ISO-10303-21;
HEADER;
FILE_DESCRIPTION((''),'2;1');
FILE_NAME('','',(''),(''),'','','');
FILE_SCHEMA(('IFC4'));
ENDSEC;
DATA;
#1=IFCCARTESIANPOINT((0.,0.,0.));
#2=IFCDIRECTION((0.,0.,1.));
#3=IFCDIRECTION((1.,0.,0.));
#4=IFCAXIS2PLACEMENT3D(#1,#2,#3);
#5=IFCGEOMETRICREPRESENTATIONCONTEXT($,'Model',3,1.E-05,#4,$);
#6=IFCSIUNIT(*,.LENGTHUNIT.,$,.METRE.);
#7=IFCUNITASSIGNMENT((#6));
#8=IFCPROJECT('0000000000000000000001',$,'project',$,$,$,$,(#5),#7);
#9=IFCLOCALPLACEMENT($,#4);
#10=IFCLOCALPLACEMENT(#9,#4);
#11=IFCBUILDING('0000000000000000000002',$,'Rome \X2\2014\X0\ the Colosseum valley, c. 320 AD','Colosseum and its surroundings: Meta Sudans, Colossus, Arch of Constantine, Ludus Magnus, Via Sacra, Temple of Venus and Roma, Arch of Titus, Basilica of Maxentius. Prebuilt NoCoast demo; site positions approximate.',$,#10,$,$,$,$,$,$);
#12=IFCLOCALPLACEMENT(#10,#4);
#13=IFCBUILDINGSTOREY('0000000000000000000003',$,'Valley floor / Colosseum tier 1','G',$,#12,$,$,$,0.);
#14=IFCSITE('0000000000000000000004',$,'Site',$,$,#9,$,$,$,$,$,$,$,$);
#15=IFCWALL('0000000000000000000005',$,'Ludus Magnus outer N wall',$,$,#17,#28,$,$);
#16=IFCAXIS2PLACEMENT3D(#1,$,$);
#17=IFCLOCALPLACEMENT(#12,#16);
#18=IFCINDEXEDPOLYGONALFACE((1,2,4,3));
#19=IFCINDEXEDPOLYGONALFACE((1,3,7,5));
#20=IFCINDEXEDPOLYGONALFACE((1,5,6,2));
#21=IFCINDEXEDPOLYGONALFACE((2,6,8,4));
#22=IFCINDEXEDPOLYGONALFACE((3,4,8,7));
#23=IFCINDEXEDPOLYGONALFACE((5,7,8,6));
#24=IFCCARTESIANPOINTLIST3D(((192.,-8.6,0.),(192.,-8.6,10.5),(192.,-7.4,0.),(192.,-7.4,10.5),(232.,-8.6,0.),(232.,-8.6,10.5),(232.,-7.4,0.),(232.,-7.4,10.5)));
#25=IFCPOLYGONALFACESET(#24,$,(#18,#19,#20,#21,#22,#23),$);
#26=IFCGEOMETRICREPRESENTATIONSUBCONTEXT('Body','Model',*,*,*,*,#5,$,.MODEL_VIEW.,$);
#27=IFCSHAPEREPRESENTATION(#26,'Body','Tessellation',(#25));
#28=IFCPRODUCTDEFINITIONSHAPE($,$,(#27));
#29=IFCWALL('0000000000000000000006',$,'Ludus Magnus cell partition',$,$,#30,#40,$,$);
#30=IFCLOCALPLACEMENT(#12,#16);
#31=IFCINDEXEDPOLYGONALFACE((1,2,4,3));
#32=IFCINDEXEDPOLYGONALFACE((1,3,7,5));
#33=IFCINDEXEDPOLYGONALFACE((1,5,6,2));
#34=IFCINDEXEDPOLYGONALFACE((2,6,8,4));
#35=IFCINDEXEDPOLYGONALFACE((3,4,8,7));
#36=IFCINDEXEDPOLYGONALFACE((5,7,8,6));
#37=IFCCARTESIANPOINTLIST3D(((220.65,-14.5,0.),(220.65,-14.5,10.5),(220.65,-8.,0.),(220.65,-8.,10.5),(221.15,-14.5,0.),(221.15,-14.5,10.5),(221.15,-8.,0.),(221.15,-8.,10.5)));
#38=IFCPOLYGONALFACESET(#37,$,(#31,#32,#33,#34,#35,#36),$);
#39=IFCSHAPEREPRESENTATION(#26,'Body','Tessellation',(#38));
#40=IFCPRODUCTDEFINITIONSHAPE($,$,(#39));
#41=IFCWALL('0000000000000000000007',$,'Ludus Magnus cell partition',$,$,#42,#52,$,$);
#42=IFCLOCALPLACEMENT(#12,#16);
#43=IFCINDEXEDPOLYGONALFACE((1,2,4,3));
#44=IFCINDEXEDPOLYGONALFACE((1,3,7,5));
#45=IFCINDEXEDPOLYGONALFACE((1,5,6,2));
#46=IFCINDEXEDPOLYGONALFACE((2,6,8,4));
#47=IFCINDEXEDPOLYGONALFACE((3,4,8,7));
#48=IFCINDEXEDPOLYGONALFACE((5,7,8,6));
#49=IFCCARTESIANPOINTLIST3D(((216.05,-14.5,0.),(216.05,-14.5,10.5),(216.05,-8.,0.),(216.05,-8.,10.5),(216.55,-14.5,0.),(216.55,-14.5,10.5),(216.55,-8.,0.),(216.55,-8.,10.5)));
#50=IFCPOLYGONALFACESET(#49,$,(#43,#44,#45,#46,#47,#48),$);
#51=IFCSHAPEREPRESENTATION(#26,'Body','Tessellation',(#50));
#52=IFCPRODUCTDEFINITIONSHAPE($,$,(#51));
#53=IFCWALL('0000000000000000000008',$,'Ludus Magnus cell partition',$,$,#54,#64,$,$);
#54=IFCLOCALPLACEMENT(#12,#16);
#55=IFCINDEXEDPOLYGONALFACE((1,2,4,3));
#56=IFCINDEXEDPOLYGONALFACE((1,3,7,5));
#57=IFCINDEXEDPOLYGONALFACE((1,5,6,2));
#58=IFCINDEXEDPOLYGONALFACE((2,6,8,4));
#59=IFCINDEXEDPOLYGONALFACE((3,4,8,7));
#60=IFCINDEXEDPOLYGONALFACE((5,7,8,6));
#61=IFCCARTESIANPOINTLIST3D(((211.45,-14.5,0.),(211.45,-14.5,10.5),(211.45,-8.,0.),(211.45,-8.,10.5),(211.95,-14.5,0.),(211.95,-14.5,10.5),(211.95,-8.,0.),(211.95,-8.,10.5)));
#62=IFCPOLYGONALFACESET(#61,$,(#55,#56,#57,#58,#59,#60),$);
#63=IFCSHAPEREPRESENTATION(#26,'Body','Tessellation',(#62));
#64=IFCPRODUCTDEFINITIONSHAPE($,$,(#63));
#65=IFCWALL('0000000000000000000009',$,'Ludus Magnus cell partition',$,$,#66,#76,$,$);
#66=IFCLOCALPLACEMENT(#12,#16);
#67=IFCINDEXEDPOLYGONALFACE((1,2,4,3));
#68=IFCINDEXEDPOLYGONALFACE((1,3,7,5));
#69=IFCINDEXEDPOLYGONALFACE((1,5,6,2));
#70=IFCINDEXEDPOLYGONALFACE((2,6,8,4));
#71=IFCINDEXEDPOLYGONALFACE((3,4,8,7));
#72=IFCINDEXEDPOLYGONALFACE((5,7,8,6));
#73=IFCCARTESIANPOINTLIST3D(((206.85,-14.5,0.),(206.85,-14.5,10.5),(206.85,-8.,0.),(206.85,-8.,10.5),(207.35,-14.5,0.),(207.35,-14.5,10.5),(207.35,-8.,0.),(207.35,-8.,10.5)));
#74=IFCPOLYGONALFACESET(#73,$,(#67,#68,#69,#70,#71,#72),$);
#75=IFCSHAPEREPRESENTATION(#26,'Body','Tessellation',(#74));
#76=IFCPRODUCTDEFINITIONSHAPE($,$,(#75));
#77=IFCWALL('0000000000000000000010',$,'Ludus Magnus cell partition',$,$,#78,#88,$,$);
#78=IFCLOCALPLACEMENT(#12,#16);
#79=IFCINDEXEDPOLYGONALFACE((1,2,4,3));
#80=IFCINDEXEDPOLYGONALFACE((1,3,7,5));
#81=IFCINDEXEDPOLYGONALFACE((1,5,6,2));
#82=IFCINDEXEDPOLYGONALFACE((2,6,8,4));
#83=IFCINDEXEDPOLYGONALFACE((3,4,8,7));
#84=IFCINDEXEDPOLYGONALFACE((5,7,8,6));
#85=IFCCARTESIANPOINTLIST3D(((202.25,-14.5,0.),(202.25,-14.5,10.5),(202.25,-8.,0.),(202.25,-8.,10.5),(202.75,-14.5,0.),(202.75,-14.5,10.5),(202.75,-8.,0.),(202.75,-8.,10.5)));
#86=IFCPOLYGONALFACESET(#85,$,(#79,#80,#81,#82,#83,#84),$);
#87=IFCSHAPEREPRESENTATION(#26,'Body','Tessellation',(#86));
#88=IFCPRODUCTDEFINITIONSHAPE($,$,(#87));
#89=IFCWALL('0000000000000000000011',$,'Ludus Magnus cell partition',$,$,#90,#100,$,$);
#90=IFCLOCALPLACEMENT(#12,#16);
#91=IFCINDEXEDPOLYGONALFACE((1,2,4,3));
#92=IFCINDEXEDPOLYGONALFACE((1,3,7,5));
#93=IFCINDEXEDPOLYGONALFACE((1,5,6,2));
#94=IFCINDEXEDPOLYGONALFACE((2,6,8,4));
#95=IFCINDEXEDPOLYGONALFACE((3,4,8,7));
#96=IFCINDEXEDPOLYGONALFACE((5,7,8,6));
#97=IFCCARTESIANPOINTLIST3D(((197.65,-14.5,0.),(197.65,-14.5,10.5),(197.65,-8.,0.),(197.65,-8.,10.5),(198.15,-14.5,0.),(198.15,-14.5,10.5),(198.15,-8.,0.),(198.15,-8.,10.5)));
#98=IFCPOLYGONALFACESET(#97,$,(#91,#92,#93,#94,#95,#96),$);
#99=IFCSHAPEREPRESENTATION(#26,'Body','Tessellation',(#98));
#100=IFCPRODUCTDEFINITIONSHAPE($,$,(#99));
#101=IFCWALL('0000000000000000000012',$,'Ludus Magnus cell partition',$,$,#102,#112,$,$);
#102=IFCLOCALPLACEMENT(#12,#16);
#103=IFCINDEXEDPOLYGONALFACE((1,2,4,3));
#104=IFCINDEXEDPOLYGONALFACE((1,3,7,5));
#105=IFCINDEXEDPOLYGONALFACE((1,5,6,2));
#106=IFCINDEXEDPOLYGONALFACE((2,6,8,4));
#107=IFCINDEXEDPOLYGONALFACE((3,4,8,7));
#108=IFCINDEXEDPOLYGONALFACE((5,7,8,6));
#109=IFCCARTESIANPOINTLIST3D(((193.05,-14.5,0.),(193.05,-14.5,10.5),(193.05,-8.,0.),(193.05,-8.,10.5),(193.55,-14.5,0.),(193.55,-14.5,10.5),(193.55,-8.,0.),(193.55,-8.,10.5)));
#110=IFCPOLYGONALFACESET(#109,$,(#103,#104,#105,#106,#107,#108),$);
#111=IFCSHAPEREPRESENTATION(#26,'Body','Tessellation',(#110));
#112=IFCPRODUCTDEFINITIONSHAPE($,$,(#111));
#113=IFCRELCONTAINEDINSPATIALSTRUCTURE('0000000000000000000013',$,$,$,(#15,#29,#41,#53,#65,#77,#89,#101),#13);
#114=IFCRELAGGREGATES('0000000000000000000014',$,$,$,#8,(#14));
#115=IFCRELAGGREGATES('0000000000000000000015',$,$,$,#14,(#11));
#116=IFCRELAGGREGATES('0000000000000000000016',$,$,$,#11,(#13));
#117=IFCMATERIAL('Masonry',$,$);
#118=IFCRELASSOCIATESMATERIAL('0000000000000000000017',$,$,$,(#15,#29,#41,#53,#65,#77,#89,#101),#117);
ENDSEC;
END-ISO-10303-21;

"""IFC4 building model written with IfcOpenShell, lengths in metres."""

from ifc_helpers import new_model, si_unit, frame, origin_with_axes, place, context, subcontext, project, spatial, indexed_curve, outline, extrude, material, element, save


model = new_model("IFC4")

# Units and contexts
model_context = context("Model", 3, precision=1e-05, world=origin_with_axes())
body_context = subcontext(model_context, "Body", "Model", "MODEL_VIEW")
ifc_project = project(units=[si_unit("LENGTHUNIT", "METRE")], contexts=[model_context])

# Site, building, storey
site_placement = place(None, origin_with_axes())
site = spatial("IfcSite", under=ifc_project, at=site_placement, Name="Site")
building_placement = place(site_placement, origin_with_axes())
building = spatial("IfcBuilding", under=site, at=building_placement, Name="Rome — the Colosseum valley, c. 320 AD", Description="Colosseum and its surroundings: Meta Sudans, Colossus, Arch of Constantine, Ludus Magnus, Via Sacra, Temple of Venus and Roma, Arch of Titus, Basilica of Maxentius. Prebuilt NoCoast demo; site positions approximate.")
storey_placement = place(building_placement, origin_with_axes())
storey = spatial("IfcBuildingStorey", under=building, at=storey_placement, Name="Valley floor / Colosseum tier 1", Description="G", Elevation=0.0)

# Walls
ifc_material = material(Name="Masonry")
wall_placement = place(storey_placement, frame((232.0, -8.0, 0.0), z_axis=(0.0, 0.0, 1.0), x_axis=(-1.0, 0.0, 0.0)))
element("IfcWall", 1, at=wall_placement, inside=storey, material=ifc_material, Name="Ludus Magnus outer N wall", context=body_context, shape_type="SweptSolid", body=[
    extrude(outline(indexed_curve([(0.0, 0.0), (0.0, 1.2), (40.0, 1.2), (40.0, 0.0), (0.0, 0.0)], self_intersect=False)), frame((0.0, -0.6, 0.0), z_axis=(0.0, 0.0, 1.0), x_axis=(1.0, 0.0, 0.0)), (0.0, 0.0, 1.0), 10.5),
])
for number, where, z_axis, x_axis, name in (
    (2, (220.9, -8.0, 0.0), (0.0, 0.0, 1.0), (0.0, -1.0, 0.0), "Ludus Magnus cell partition"),
    (3, (216.3, -8.0, 0.0), (0.0, 0.0, 1.0), (0.0, -1.0, 0.0), "Ludus Magnus cell partition"),
    (4, (211.7, -8.0, 0.0), (0.0, 0.0, 1.0), (0.0, -1.0, 0.0), "Ludus Magnus cell partition"),
    (5, (207.1, -8.0, 0.0), (0.0, 0.0, 1.0), (0.0, -1.0, 0.0), "Ludus Magnus cell partition"),
    (6, (202.5, -8.0, 0.0), (0.0, 0.0, 1.0), (0.0, -1.0, 0.0), "Ludus Magnus cell partition"),
    (7, (197.9, -8.0, 0.0), (0.0, 0.0, 1.0), (0.0, -1.0, 0.0), "Ludus Magnus cell partition"),
    (8, (193.3, -8.0, 0.0), (0.0, 0.0, 1.0), (0.0, -1.0, 0.0), "Ludus Magnus cell partition"),
):
    element("IfcWall", number, at=place(storey_placement, frame(where, z_axis=z_axis, x_axis=x_axis)), inside=storey, material=ifc_material, Name=name, context=body_context, shape_type="SweptSolid", body=[
        extrude(outline(indexed_curve([(0.0, 0.0), (0.0, 0.5), (6.5, 0.5), (6.5, 0.0), (0.0, 0.0)], self_intersect=False)), frame((0.0, -0.25, 0.0), z_axis=(0.0, 0.0, 1.0), x_axis=(1.0, 0.0, 0.0)), (0.0, 0.0, 1.0), 10.5),
    ])

save(model, "model.ifc")
